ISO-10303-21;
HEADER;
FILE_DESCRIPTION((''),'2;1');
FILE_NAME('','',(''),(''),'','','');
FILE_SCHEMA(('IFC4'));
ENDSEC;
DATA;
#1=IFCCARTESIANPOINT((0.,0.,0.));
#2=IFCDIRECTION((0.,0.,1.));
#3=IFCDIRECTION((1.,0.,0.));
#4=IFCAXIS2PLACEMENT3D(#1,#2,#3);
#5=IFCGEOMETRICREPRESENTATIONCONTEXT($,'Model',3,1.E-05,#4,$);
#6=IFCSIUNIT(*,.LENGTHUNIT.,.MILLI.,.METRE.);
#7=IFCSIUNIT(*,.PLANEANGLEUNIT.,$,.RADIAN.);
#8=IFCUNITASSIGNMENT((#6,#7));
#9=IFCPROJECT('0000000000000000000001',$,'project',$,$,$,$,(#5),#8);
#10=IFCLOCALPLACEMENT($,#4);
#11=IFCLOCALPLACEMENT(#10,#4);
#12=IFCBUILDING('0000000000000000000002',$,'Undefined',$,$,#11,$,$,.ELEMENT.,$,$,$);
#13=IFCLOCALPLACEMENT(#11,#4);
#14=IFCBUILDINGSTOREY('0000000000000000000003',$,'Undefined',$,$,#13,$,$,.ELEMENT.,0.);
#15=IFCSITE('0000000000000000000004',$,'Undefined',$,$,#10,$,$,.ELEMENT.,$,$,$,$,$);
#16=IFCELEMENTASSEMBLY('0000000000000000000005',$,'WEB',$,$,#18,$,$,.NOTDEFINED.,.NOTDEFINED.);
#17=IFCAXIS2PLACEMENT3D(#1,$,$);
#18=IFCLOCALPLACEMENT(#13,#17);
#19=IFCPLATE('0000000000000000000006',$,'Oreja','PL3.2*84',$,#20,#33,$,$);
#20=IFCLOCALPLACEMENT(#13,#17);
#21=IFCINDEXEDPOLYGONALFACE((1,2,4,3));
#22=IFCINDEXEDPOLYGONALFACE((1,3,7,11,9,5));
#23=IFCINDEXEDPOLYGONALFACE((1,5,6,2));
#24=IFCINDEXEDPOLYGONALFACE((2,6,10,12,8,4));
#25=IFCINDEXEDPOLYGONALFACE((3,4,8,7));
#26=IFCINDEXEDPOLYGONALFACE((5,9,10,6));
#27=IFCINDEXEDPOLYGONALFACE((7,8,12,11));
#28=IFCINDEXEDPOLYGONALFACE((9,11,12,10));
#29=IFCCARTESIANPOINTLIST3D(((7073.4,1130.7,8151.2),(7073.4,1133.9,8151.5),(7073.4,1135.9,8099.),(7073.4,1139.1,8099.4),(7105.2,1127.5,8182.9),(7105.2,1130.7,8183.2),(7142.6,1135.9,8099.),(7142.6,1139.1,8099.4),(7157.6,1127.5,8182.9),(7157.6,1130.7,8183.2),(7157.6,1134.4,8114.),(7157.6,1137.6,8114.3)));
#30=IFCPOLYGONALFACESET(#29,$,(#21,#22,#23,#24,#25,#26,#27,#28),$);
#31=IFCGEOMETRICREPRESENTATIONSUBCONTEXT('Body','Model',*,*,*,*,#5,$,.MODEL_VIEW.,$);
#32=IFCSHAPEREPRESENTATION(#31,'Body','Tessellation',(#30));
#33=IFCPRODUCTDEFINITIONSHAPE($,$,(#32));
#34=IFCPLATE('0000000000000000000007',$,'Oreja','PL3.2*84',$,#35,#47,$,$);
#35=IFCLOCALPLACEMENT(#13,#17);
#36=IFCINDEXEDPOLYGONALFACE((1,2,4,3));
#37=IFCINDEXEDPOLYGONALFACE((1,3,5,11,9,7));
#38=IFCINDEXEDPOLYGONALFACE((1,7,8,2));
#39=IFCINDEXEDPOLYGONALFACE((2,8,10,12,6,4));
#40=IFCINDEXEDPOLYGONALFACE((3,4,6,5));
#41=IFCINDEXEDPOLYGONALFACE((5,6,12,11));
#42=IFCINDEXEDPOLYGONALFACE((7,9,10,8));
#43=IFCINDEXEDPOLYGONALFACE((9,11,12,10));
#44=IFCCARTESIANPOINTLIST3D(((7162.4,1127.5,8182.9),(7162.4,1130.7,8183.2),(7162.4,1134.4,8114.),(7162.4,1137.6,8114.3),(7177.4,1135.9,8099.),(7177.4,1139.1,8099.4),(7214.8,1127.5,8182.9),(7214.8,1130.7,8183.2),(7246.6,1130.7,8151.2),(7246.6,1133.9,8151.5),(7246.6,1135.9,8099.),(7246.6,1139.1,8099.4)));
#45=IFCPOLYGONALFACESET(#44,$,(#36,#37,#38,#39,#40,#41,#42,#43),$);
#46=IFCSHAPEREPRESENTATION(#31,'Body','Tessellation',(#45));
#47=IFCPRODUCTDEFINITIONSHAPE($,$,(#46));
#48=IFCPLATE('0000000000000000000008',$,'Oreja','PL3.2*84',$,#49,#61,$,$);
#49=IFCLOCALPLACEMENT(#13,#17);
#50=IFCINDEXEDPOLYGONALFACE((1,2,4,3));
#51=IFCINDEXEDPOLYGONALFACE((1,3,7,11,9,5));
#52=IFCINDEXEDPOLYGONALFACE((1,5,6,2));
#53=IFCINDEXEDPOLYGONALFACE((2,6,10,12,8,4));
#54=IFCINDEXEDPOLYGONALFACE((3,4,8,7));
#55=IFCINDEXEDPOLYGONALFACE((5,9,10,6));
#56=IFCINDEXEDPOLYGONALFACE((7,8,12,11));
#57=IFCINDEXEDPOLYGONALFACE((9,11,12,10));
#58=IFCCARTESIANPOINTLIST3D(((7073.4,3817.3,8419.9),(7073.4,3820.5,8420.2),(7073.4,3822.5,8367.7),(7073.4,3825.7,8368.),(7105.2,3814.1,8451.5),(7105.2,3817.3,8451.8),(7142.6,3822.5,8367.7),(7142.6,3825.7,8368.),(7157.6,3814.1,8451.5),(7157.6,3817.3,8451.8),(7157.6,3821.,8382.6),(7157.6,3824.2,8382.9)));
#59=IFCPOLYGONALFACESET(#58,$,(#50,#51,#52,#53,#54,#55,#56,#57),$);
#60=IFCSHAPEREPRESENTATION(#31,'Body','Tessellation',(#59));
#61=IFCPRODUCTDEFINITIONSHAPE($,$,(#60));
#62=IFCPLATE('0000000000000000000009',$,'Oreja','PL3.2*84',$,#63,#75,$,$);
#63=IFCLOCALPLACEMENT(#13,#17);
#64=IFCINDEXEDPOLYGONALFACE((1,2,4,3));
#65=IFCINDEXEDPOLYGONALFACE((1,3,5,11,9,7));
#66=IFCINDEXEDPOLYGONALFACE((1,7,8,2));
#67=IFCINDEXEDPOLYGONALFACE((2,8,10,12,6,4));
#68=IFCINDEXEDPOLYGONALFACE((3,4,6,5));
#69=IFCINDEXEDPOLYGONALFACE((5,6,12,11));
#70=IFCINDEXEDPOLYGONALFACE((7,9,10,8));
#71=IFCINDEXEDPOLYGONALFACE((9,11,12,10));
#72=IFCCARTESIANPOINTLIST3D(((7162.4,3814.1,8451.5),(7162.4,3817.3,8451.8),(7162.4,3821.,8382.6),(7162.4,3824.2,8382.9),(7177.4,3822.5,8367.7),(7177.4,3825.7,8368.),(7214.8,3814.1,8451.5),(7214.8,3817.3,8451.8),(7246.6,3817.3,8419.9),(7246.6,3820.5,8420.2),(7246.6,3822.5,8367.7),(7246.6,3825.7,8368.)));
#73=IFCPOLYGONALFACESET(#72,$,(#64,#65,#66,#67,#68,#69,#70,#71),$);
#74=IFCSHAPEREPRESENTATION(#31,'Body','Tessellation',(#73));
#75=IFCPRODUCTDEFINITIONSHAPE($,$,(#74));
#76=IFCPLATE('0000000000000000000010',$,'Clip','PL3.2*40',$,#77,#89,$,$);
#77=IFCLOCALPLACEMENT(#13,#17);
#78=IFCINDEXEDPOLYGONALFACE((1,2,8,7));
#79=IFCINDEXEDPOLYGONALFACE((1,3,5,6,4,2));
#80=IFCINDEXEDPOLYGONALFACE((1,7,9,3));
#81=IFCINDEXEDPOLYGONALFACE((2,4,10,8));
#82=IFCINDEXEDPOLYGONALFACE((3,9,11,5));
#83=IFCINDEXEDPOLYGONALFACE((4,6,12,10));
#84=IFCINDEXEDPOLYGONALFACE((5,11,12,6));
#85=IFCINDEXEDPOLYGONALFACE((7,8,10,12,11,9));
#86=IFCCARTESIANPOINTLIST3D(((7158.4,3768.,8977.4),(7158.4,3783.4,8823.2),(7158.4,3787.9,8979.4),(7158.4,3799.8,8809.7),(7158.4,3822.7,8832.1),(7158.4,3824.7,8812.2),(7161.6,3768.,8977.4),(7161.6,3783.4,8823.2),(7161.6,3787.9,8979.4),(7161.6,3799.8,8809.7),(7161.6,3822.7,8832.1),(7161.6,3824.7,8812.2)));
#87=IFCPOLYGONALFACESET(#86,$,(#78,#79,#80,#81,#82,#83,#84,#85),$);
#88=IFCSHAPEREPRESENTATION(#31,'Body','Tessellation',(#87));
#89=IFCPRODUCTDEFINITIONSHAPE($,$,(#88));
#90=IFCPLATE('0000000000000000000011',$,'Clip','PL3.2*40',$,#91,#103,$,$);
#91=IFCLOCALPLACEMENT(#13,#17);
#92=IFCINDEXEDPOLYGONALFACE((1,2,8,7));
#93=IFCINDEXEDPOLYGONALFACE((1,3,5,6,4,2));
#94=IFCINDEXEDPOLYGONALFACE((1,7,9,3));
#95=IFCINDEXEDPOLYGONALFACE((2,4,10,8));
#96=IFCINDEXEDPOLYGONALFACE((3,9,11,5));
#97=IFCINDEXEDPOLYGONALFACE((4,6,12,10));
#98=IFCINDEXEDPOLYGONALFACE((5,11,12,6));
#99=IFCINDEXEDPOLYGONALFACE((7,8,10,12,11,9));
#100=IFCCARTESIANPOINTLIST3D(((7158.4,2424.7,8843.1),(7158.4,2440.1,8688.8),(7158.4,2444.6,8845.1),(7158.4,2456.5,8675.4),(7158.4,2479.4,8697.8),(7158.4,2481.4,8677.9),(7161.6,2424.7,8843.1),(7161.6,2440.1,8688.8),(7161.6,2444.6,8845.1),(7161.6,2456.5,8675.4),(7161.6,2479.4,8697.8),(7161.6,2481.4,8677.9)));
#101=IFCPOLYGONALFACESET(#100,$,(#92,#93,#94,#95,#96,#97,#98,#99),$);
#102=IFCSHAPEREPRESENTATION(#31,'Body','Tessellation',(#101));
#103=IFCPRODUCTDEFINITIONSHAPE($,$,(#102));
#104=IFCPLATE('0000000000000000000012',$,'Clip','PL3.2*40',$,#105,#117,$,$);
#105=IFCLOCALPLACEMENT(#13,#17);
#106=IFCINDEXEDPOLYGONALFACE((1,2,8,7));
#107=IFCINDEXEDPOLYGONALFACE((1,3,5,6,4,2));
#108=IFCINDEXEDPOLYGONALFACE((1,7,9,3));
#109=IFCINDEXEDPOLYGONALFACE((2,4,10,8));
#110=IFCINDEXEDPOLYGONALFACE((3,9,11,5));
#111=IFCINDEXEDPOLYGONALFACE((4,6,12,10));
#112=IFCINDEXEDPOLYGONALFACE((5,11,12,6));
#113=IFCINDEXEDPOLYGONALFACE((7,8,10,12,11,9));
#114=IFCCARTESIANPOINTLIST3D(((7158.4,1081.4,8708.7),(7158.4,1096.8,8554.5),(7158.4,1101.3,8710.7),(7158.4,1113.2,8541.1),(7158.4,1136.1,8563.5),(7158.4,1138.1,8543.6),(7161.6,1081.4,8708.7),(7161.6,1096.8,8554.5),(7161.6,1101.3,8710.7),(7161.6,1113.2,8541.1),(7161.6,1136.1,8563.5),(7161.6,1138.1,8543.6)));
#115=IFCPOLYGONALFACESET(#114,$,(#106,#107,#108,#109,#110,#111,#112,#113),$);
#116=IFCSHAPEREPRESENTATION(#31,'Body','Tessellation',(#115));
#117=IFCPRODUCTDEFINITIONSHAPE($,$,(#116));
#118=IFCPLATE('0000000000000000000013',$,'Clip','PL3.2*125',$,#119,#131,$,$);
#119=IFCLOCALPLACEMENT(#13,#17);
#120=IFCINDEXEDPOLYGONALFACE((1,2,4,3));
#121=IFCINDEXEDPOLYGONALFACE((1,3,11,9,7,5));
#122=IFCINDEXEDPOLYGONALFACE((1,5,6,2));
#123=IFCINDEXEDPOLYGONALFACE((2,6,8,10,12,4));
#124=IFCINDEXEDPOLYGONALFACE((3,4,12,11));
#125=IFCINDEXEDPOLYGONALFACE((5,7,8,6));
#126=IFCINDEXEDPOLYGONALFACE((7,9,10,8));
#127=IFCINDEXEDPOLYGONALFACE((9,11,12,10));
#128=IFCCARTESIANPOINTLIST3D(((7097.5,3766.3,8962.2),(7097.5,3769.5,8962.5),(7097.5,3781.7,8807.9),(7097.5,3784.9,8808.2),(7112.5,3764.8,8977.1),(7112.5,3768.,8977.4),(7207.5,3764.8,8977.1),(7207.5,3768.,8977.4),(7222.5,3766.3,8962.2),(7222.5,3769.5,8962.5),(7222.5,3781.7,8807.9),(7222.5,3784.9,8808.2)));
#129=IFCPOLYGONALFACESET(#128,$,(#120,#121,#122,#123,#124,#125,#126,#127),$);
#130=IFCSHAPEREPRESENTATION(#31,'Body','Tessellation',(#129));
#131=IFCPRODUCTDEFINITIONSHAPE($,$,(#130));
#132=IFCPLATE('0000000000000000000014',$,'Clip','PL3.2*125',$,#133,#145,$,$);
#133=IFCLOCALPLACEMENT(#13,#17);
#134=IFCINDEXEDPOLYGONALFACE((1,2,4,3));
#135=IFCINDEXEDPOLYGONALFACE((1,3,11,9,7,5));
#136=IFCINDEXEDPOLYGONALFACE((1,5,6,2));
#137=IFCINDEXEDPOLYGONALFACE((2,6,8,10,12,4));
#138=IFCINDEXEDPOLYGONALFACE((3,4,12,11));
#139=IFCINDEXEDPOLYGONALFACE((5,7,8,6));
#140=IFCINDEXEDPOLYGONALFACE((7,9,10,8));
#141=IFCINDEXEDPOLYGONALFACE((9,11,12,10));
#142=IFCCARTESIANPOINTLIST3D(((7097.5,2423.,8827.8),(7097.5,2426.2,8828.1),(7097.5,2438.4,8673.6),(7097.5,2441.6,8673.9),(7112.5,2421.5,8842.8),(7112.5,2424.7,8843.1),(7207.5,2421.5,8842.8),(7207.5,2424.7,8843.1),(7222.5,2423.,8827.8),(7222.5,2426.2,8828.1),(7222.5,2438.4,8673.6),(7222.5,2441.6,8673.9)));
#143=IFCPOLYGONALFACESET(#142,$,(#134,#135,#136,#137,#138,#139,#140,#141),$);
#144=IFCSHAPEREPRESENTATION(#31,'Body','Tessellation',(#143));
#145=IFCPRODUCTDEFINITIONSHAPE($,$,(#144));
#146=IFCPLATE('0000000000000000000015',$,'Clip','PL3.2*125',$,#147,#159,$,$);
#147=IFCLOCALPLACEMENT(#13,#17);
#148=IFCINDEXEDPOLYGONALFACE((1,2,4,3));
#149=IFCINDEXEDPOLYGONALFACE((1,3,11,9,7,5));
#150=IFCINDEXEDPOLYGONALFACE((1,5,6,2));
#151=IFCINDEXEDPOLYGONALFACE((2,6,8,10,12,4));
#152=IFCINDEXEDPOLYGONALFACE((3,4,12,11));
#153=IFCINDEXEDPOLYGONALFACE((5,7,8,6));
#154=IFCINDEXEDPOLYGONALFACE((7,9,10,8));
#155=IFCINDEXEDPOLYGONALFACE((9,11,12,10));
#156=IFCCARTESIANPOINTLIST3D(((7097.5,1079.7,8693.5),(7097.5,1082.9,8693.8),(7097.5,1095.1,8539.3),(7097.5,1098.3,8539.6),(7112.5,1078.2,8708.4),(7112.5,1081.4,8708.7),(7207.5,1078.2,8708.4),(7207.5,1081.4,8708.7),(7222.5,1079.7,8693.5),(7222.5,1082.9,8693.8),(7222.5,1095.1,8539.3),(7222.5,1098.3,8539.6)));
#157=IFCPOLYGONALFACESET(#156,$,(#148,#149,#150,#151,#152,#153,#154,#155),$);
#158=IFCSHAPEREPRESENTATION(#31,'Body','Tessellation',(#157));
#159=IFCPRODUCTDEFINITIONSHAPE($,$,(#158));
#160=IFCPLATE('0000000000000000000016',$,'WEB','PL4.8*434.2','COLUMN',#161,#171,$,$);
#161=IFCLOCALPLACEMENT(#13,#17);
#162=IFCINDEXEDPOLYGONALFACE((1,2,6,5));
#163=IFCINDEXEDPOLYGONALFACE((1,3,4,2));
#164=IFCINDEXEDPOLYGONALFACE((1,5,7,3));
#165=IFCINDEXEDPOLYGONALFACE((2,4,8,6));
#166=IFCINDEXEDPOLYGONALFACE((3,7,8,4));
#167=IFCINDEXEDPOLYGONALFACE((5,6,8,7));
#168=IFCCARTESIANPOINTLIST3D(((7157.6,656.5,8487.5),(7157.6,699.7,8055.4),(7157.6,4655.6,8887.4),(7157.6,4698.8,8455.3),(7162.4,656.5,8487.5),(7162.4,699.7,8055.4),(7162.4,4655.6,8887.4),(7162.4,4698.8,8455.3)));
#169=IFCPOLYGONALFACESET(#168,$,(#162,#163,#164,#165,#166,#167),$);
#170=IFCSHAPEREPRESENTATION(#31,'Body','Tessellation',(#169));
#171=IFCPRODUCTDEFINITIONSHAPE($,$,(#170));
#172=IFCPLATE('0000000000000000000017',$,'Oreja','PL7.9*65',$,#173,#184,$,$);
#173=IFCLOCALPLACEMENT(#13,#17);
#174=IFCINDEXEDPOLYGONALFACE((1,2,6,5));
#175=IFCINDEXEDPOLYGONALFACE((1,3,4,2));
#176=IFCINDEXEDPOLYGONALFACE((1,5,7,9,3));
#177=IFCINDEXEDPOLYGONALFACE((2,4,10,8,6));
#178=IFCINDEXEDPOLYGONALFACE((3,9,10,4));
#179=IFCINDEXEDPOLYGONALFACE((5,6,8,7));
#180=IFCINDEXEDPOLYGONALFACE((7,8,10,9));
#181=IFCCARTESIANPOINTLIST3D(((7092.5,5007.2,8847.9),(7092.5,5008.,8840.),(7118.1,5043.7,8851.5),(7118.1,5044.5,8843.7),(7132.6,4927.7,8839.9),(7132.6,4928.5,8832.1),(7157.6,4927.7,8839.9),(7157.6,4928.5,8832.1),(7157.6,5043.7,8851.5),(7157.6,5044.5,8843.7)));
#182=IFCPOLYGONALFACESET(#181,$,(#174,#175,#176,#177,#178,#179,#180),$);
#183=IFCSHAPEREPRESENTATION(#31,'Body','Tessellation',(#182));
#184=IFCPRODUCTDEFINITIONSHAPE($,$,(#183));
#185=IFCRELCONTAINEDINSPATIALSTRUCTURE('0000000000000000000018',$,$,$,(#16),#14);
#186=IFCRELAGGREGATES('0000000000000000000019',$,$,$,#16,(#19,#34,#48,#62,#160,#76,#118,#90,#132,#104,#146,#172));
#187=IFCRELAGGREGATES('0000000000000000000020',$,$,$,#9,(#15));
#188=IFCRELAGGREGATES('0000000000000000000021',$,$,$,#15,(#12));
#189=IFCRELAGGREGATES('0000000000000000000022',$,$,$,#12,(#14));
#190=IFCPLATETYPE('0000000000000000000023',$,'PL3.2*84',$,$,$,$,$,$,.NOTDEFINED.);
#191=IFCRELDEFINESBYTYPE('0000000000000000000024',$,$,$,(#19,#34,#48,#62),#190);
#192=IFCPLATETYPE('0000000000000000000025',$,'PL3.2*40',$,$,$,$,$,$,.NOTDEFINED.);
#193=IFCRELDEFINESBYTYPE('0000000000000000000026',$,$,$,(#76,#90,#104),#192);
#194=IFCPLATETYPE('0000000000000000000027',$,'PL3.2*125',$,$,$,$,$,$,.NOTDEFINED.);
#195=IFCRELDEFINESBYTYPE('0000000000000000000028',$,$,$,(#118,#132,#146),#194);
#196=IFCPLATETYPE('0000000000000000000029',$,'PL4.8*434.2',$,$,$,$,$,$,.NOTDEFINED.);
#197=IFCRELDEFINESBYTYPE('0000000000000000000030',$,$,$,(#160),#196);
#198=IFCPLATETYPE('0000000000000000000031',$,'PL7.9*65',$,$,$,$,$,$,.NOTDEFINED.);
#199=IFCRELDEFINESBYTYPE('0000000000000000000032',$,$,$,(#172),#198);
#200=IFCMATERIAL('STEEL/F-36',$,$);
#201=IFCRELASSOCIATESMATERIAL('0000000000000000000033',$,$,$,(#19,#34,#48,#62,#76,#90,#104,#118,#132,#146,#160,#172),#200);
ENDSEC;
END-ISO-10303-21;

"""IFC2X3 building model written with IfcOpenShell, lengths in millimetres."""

from ifc_helpers import new_model, si_unit, frame, origin_with_axes, place, context, subcontext, project, spatial, polyline, outline, extrude, material, type_object, element, aggregate, save


model = new_model("IFC2X3")

# Units and contexts
model_context = context("Model", 3, precision=1e-05, world=origin_with_axes())
body_context = subcontext(model_context, "Body", "Model", "MODEL_VIEW")
ifc_project = project(units=[si_unit("LENGTHUNIT", "METRE", prefix="MILLI"), si_unit("PLANEANGLEUNIT", "RADIAN")], contexts=[model_context])

# Site, building, storey
site_placement = place(None, origin_with_axes())
site = spatial("IfcSite", under=ifc_project, at=site_placement, Name="Undefined", CompositionType="ELEMENT")
building_placement = place(site_placement, origin_with_axes())
building = spatial("IfcBuilding", under=site, at=building_placement, Name="Undefined", CompositionType="ELEMENT")
storey_placement = place(building_placement, origin_with_axes())
storey = spatial("IfcBuildingStorey", under=building, at=storey_placement, Name="Undefined", CompositionType="ELEMENT", Elevation=0.0)

# Element assembly, plates
assembly_1_placement = place(storey_placement, origin_with_axes())
assembly_1 = element("IfcElementAssembly", 1, at=assembly_1_placement, inside=storey, Name="WEB", AssemblyPlace="NOTDEFINED", PredefinedType="NOTDEFINED")
ifc_material_1 = material(Name="STEEL/F-36")
plate_type_1 = type_object("IfcPlateType", Name="PL3.2*84", PredefinedType="NOTDEFINED")
plate_1_placement = place(assembly_1_placement, frame((7157.6, 1137.5, 8099.2), z_axis=(0.0, 0.995037, 0.099504), x_axis=(-1.0, 0.0, 0.0)))
plate_1 = element("IfcPlate", 2, at=plate_1_placement, type_object=plate_type_1, material=ifc_material_1, Name="Oreja", Description="PL3.2*84", context=body_context, shape_type="SweptSolid", body=[
    extrude(outline(polyline([(0.0, 15.0), (15.0, 0.0), (84.2, 0.0), (84.2, 52.4), (52.4, 84.2), (0.0, 84.2), (0.0, 15.0)])), frame((0.0, 0.0, -1.6), z_axis=(0.0, 0.0, 1.0), x_axis=(1.0, 0.0, 0.0)), (0.0, 0.0, 1.0), 3.2),
])
plate_2_placement = place(assembly_1_placement, frame((7162.4, 1137.5, 8099.2), z_axis=(0.0, -0.995037, -0.099504), x_axis=(1.0, 0.0, 0.0)))
plate_2 = element("IfcPlate", 3, at=plate_2_placement, type_object=plate_type_1, material=ifc_material_1, Name="Oreja", Description="PL3.2*84", context=body_context, shape_type="SweptSolid", body=[
    extrude(outline(polyline([(0.0, 15.0), (15.0, 0.0), (84.2, 0.0), (84.2, 52.4), (52.4, 84.2), (0.0, 84.2), (0.0, 15.0)])), frame((0.0, 0.0, -1.6), z_axis=(0.0, 0.0, 1.0), x_axis=(1.0, 0.0, 0.0)), (0.0, 0.0, 1.0), 3.2),
])
plate_3_placement = place(assembly_1_placement, frame((7157.6, 3824.1, 8367.9), z_axis=(0.0, 0.995037, 0.099504), x_axis=(-1.0, 0.0, 0.0)))
plate_3 = element("IfcPlate", 4, at=plate_3_placement, type_object=plate_type_1, material=ifc_material_1, Name="Oreja", Description="PL3.2*84", context=body_context, shape_type="SweptSolid", body=[
    extrude(outline(polyline([(0.0, 15.0), (15.0, 0.0), (84.2, 0.0), (84.2, 52.4), (52.4, 84.2), (0.0, 84.2), (0.0, 15.0)])), frame((0.0, 0.0, -1.6), z_axis=(0.0, 0.0, 1.0), x_axis=(1.0, 0.0, 0.0)), (0.0, 0.0, 1.0), 3.2),
])
plate_4_placement = place(assembly_1_placement, frame((7162.4, 3824.1, 8367.9), z_axis=(0.0, -0.995037, -0.099504), x_axis=(1.0, 0.0, 0.0)))
plate_4 = element("IfcPlate", 5, at=plate_4_placement, type_object=plate_type_1, material=ifc_material_1, Name="Oreja", Description="PL3.2*84", context=body_context, shape_type="SweptSolid", body=[
    extrude(outline(polyline([(0.0, 15.0), (15.0, 0.0), (84.2, 0.0), (84.2, 52.4), (52.4, 84.2), (0.0, 84.2), (0.0, 15.0)])), frame((0.0, 0.0, -1.6), z_axis=(0.0, 0.0, 1.0), x_axis=(1.0, 0.0, 0.0)), (0.0, 0.0, 1.0), 3.2),
])
plate_type_2 = type_object("IfcPlateType", Name="PL3.2*40", PredefinedType="NOTDEFINED")
plate_5_placement = place(assembly_1_placement, frame((7160.0, 3824.7, 8812.2), z_axis=(-1.0, 0.0, 0.0), x_axis=(0.0, -0.995037, -0.099504)))
plate_5 = element("IfcPlate", 6, at=plate_5_placement, type_object=plate_type_2, material=ifc_material_1, Name="Clip", Description="PL3.2*40", context=body_context, shape_type="SweptSolid", body=[
    extrude(outline(polyline([(0.0, 0.0), (25.0, 0.0), (40.0, 15.0), (40.0, 170.0), (20.0, 170.0), (0.0, 20.0), (0.0, 0.0)])), frame((0.0, 0.0, -1.6), z_axis=(0.0, 0.0, 1.0), x_axis=(1.0, 0.0, 0.0)), (0.0, 0.0, 1.0), 3.2),
])
plate_6_placement = place(assembly_1_placement, frame((7160.0, 2481.4, 8677.9), z_axis=(-1.0, 0.0, 0.0), x_axis=(0.0, -0.995037, -0.099504)))
plate_6 = element("IfcPlate", 7, at=plate_6_placement, type_object=plate_type_2, material=ifc_material_1, Name="Clip", Description="PL3.2*40", context=body_context, shape_type="SweptSolid", body=[
    extrude(outline(polyline([(0.0, 0.0), (25.0, 0.0), (40.0, 15.0), (40.0, 170.0), (20.0, 170.0), (0.0, 20.0), (0.0, 0.0)])), frame((0.0, 0.0, -1.6), z_axis=(0.0, 0.0, 1.0), x_axis=(1.0, 0.0, 0.0)), (0.0, 0.0, 1.0), 3.2),
])
plate_7_placement = place(assembly_1_placement, frame((7160.0, 1138.1, 8543.6), z_axis=(-1.0, 0.0, 0.0), x_axis=(0.0, -0.995037, -0.099504)))
plate_7 = element("IfcPlate", 8, at=plate_7_placement, type_object=plate_type_2, material=ifc_material_1, Name="Clip", Description="PL3.2*40", context=body_context, shape_type="SweptSolid", body=[
    extrude(outline(polyline([(0.0, 0.0), (25.0, 0.0), (40.0, 15.0), (40.0, 170.0), (20.0, 170.0), (0.0, 20.0), (0.0, 0.0)])), frame((0.0, 0.0, -1.6), z_axis=(0.0, 0.0, 1.0), x_axis=(1.0, 0.0, 0.0)), (0.0, 0.0, 1.0), 3.2),
])
plate_type_3 = type_object("IfcPlateType", Name="PL3.2*125", PredefinedType="NOTDEFINED")
plate_8_placement = place(assembly_1_placement, frame((7222.5, 3783.3, 8808.1), z_axis=(0.0, 0.995037, 0.099504), x_axis=(-1.0, 0.0, 0.0)))
plate_8 = element("IfcPlate", 9, at=plate_8_placement, type_object=plate_type_3, material=ifc_material_1, Name="Clip", Description="PL3.2*125", context=body_context, shape_type="SweptSolid", body=[
    extrude(outline(polyline([(0.0, 0.0), (125.0, 0.0), (125.0, 155.0), (110.0, 170.0), (15.0, 170.0), (0.0, 155.0), (0.0, 0.0)])), frame((0.0, 0.0, -1.6), z_axis=(0.0, 0.0, 1.0), x_axis=(1.0, 0.0, 0.0)), (0.0, 0.0, 1.0), 3.2),
])
plate_9_placement = place(assembly_1_placement, frame((7222.5, 2440.0, 8673.8), z_axis=(0.0, 0.995037, 0.099504), x_axis=(-1.0, 0.0, 0.0)))
plate_9 = element("IfcPlate", 10, at=plate_9_placement, type_object=plate_type_3, material=ifc_material_1, Name="Clip", Description="PL3.2*125", context=body_context, shape_type="SweptSolid", body=[
    extrude(outline(polyline([(0.0, 0.0), (125.0, 0.0), (125.0, 155.0), (110.0, 170.0), (15.0, 170.0), (0.0, 155.0), (0.0, 0.0)])), frame((0.0, 0.0, -1.6), z_axis=(0.0, 0.0, 1.0), x_axis=(1.0, 0.0, 0.0)), (0.0, 0.0, 1.0), 3.2),
])
plate_10_placement = place(assembly_1_placement, frame((7222.5, 1096.7, 8539.4), z_axis=(0.0, 0.995037, 0.099504), x_axis=(-1.0, 0.0, 0.0)))
plate_10 = element("IfcPlate", 11, at=plate_10_placement, type_object=plate_type_3, material=ifc_material_1, Name="Clip", Description="PL3.2*125", context=body_context, shape_type="SweptSolid", body=[
    extrude(outline(polyline([(0.0, 0.0), (125.0, 0.0), (125.0, 155.0), (110.0, 170.0), (15.0, 170.0), (0.0, 155.0), (0.0, 0.0)])), frame((0.0, 0.0, -1.6), z_axis=(0.0, 0.0, 1.0), x_axis=(1.0, 0.0, 0.0)), (0.0, 0.0, 1.0), 3.2),
])
plate_type_4 = type_object("IfcPlateType", Name="PL4.8*434.2", PredefinedType="NOTDEFINED")
plate_11_placement = place(assembly_1_placement, frame((7160.0, 4677.2, 8671.3), z_axis=(1.0, 0.0, 0.0), x_axis=(0.0, -0.995037, -0.099504)))
plate_11 = element("IfcPlate", 12, at=plate_11_placement, type_object=plate_type_4, material=ifc_material_1, Name="WEB", Description="PL4.8*434.2", ObjectType="COLUMN", context=body_context, shape_type="SweptSolid", body=[
    extrude(outline(polyline([(0.0, -217.1), (0.0, 217.1), (4019.1, 217.1), (4019.1, -217.1), (0.0, -217.1)])), frame((0.0, 0.0, -2.4), z_axis=(0.0, 0.0, 1.0), x_axis=(1.0, 0.0, 0.0)), (0.0, 0.0, 1.0), 4.8),
])
plate_type_5 = type_object("IfcPlateType", Name="PL7.9*65", PredefinedType="NOTDEFINED")
plate_12_placement = place(assembly_1_placement, frame((7157.6, 4928.1, 8836.0), z_axis=(0.0, -0.099492, 0.995038), x_axis=(0.0, 0.995038, 0.099492)))
plate_12 = element("IfcPlate", 13, at=plate_12_placement, type_object=plate_type_5, material=ifc_material_1, Name="Oreja", Description="PL7.9*65", context=body_context, shape_type="SweptSolid", body=[
    extrude(outline(polyline([(0.0, 0.0), (116.6, 0.0), (116.6, 39.5), (79.9, 65.1), (0.0, 25.0), (0.0, 0.0)])), frame((0.0, 0.0, -4.0), z_axis=(0.0, 0.0, 1.0), x_axis=(1.0, 0.0, 0.0)), (0.0, 0.0, 1.0), 7.9),
])
aggregate(assembly_1, [plate_1, plate_2, plate_3, plate_4, plate_11, plate_5, plate_8, plate_6, plate_9, plate_7, plate_10, plate_12])

save(model, "model.ifc")
